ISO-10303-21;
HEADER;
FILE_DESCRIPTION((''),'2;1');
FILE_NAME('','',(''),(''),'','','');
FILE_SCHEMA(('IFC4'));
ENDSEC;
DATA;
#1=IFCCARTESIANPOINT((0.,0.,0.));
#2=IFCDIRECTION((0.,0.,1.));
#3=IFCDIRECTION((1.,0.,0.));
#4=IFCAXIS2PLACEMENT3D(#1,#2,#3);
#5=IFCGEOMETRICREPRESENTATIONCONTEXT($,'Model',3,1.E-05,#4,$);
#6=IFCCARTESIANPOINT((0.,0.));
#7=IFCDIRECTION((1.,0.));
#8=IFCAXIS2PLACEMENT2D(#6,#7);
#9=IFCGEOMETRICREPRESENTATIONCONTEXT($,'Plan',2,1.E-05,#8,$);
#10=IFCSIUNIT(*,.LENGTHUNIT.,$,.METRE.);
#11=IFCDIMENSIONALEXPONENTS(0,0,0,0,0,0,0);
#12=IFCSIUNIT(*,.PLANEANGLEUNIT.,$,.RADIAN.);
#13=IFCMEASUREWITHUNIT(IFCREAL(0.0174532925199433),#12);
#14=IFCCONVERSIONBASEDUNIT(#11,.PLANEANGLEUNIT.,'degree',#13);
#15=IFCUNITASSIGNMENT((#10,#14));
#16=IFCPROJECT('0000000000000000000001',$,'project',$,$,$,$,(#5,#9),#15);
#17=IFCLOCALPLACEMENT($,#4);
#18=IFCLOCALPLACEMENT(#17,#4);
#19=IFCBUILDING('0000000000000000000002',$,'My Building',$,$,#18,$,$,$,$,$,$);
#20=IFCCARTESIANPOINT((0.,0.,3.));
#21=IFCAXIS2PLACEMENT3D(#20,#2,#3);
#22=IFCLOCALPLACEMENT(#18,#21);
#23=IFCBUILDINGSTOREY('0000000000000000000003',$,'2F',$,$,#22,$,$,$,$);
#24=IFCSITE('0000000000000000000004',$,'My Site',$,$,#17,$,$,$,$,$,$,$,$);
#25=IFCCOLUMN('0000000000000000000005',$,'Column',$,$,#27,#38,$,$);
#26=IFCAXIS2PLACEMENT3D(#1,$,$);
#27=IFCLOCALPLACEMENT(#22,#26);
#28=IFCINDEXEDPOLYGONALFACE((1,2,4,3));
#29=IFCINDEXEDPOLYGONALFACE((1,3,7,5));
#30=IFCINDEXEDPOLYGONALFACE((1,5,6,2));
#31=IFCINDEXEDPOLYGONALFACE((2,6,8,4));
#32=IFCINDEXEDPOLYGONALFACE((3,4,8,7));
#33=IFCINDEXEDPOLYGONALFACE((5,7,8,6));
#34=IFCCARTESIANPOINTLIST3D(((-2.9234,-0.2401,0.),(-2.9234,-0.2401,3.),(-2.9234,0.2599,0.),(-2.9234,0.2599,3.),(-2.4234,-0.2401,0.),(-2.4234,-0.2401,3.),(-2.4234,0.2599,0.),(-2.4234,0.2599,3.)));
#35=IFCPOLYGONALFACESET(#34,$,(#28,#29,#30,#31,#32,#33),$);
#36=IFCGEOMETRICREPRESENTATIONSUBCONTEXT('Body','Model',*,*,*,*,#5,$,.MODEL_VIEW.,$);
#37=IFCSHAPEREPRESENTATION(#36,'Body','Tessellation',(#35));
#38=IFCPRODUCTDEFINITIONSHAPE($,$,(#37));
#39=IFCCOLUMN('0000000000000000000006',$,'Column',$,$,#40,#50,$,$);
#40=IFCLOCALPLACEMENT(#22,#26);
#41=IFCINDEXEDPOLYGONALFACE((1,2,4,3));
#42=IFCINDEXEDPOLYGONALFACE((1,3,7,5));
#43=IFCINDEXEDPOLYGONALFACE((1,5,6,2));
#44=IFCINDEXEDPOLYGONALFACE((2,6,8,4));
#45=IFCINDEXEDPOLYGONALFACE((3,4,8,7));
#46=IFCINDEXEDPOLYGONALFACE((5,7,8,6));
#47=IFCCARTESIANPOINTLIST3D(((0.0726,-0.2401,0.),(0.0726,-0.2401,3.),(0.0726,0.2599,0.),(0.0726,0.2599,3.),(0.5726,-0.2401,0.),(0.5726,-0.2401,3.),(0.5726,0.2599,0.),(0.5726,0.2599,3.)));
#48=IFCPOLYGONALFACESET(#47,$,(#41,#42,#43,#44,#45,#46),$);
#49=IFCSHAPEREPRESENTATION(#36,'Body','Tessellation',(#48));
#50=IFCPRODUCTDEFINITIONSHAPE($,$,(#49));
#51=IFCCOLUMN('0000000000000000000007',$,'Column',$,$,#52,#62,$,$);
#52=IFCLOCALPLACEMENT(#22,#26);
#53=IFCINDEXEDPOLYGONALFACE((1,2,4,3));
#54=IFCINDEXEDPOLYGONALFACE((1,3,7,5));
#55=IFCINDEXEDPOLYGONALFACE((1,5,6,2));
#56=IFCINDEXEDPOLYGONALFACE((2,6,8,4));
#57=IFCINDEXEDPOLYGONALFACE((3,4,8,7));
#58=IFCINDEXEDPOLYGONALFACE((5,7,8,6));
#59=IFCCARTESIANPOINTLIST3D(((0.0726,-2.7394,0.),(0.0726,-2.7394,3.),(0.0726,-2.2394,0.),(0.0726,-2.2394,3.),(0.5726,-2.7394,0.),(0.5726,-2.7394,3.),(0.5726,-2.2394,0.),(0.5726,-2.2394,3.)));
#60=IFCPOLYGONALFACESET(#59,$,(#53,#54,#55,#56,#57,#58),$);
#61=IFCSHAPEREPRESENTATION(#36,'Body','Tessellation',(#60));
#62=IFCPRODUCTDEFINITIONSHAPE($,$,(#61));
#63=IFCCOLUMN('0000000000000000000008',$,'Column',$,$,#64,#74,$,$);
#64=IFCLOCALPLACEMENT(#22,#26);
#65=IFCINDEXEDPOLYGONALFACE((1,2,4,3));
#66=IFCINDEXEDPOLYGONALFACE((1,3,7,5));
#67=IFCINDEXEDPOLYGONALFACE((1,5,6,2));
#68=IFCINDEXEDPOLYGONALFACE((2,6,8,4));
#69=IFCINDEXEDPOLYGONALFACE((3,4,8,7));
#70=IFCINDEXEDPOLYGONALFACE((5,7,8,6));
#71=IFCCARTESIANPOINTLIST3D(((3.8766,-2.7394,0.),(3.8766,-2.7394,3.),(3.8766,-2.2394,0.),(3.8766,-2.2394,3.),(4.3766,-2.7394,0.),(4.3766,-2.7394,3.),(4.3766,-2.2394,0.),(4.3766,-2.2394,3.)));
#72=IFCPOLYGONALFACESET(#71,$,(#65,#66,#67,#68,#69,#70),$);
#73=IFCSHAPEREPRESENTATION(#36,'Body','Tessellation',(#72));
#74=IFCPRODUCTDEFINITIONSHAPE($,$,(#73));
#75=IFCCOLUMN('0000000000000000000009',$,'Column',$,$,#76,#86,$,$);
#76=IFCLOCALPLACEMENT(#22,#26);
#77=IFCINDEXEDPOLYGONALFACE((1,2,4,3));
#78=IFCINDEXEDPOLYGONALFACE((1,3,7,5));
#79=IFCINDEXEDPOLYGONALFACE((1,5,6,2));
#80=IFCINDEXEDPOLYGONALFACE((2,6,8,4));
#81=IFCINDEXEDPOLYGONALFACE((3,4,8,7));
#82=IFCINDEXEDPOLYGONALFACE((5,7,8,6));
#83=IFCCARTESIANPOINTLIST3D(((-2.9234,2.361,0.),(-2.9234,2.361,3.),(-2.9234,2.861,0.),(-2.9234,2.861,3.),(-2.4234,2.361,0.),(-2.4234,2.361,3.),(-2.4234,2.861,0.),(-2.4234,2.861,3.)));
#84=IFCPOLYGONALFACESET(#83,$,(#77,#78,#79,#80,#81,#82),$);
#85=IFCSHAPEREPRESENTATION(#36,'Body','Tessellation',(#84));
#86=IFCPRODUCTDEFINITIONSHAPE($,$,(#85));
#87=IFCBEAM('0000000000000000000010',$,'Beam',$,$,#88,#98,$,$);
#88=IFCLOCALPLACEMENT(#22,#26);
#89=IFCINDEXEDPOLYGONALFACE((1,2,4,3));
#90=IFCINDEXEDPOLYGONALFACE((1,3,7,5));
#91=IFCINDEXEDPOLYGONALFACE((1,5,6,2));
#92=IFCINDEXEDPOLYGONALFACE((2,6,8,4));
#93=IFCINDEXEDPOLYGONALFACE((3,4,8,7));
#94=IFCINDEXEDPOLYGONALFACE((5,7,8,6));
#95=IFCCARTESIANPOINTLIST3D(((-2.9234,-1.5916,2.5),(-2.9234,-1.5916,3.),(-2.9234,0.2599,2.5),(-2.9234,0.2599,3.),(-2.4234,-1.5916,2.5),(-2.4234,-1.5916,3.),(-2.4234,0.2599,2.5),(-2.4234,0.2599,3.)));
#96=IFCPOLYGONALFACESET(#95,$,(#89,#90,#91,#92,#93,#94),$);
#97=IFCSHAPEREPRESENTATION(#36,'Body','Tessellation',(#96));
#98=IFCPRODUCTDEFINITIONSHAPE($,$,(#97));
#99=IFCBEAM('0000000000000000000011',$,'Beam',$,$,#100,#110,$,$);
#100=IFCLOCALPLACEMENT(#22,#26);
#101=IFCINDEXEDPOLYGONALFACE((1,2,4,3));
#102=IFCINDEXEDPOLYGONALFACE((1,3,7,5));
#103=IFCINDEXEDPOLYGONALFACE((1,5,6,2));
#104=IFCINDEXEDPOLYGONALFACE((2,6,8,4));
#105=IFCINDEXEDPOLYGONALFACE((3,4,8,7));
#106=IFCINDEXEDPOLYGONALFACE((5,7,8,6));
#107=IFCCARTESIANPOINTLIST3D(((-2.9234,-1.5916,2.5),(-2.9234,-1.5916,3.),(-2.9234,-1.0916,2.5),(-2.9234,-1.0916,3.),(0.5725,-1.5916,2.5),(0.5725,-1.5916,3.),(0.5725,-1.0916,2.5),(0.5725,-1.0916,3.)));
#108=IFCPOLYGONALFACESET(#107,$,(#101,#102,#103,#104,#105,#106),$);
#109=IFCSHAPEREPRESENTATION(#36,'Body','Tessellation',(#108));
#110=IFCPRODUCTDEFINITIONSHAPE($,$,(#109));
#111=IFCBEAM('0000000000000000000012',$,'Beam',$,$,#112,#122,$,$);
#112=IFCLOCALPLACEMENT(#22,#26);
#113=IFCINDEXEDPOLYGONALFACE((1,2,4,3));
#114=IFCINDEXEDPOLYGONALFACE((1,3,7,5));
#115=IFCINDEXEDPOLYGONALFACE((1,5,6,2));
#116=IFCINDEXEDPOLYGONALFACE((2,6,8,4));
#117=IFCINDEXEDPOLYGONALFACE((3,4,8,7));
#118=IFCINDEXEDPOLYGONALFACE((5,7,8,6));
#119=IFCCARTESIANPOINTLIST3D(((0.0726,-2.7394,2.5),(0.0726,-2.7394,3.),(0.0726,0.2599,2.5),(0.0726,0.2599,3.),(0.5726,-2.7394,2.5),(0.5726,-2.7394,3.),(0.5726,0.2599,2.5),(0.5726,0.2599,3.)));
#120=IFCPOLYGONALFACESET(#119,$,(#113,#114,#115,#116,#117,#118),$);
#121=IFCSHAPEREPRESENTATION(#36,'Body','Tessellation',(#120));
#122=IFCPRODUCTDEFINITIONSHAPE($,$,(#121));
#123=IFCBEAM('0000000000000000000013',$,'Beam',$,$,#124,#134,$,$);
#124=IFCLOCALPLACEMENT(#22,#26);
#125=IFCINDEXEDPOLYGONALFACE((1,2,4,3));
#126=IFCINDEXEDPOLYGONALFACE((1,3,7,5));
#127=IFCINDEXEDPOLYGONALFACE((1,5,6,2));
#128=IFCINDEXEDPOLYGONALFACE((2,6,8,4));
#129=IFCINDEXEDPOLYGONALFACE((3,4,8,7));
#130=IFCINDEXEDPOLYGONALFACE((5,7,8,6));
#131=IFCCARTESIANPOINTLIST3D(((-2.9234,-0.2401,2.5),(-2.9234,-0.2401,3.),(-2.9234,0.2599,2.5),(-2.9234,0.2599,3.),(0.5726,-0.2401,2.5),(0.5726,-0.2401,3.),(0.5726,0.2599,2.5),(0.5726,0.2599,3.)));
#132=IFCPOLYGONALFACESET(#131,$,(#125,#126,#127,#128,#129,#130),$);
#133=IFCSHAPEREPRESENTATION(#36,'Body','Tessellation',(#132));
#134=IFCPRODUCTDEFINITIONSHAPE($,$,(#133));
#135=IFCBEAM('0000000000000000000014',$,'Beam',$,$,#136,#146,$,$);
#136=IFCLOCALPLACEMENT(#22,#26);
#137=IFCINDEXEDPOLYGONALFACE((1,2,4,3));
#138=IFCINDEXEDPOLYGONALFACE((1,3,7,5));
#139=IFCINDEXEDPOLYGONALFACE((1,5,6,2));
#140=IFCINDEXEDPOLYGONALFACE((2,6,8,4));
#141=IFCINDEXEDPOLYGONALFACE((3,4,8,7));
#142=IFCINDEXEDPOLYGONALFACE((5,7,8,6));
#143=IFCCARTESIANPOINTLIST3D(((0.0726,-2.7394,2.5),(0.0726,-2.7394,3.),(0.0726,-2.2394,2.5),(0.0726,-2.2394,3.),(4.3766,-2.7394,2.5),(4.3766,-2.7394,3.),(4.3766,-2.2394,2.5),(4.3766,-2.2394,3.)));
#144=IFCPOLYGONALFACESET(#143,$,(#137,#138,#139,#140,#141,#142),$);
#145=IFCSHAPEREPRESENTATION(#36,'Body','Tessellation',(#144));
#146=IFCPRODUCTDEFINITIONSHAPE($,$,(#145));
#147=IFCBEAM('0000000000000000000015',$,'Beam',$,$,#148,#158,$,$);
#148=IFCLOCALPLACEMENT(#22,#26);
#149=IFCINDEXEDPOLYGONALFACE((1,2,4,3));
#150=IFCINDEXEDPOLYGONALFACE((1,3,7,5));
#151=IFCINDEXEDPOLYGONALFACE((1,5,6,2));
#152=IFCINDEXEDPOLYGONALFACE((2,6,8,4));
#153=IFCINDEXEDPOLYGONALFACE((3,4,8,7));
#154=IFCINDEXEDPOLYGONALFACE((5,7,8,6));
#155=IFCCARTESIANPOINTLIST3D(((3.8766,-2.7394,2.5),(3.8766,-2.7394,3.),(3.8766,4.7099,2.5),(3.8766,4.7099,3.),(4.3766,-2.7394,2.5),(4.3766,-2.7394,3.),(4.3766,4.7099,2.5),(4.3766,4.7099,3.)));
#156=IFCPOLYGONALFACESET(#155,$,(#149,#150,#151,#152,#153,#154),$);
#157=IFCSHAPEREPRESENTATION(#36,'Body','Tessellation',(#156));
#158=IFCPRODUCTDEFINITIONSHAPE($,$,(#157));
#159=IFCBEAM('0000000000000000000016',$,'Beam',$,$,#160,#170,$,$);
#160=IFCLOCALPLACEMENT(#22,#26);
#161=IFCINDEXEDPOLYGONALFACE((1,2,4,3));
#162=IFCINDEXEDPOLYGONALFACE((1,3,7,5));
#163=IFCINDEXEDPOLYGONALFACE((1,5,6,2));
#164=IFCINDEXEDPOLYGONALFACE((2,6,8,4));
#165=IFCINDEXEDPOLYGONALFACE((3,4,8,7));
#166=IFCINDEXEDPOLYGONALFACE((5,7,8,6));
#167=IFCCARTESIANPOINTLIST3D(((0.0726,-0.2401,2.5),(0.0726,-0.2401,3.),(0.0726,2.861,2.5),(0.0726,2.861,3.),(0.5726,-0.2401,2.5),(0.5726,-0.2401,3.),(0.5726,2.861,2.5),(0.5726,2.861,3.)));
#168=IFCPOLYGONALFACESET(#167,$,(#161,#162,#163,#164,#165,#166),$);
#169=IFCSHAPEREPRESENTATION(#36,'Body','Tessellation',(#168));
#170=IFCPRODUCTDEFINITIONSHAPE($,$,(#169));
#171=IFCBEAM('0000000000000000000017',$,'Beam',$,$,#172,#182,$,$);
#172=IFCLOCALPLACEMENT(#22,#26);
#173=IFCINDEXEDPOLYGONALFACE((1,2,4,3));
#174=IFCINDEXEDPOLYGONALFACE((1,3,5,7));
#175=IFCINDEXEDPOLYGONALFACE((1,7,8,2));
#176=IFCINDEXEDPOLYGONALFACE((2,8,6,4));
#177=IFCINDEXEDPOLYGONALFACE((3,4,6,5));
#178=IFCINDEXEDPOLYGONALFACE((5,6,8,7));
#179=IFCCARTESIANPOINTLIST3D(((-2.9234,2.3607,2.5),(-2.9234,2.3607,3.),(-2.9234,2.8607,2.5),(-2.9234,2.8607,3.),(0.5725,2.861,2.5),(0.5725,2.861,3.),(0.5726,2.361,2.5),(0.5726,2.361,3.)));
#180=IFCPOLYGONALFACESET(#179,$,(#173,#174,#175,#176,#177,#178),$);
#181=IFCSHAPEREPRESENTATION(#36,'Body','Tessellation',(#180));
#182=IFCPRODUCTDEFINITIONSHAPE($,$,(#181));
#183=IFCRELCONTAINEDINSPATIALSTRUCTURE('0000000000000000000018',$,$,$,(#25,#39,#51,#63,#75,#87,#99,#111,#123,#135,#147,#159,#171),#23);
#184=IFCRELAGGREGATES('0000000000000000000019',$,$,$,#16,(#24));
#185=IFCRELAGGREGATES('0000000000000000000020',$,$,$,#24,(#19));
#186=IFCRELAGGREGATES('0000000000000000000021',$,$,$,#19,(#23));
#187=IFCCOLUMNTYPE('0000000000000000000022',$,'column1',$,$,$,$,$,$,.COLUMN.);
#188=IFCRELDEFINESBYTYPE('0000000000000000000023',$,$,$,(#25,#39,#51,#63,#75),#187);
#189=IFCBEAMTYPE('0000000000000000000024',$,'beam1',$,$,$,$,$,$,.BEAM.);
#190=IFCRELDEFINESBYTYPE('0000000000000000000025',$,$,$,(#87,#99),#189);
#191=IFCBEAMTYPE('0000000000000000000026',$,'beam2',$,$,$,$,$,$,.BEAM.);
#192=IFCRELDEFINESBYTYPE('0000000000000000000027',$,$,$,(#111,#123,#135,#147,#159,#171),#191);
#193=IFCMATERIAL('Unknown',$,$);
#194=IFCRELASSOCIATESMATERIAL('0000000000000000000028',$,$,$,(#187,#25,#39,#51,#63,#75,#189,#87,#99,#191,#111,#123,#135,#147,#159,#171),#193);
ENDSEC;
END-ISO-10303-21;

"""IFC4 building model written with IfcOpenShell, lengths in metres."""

from ifc_helpers import new_model, entity, si_unit, converted_unit, frame, origin_with_axes, origin_2d_with_axis, place, context, subcontext, project, spatial, rectangle, extrude, material, material_profile, profile_set, profile_usage, type_object, element, save


model = new_model("IFC4")

# Units and contexts
model_context = context("Model", 3, precision=1e-05, world=origin_with_axes())
plan_context = context("Plan", 2, precision=1e-05, world=origin_2d_with_axis())
body_context_1 = subcontext(model_context, "Body", "Model", "MODEL_VIEW")
ifc_project = project(units=[si_unit("LENGTHUNIT", "METRE"), converted_unit("PLANEANGLEUNIT", "degree", entity("IfcReal", 0.0174532925199433), si_unit("PLANEANGLEUNIT", "RADIAN"), dimensions=[0, 0, 0, 0, 0, 0, 0])], contexts=[model_context, plan_context])

# Site, building, storey
site_placement = place(None, origin_with_axes())
site = spatial("IfcSite", under=ifc_project, at=site_placement, Name="My Site")
building_placement = place(site_placement, origin_with_axes())
building = spatial("IfcBuilding", under=site, at=building_placement, Name="My Building")
storey_placement = place(building_placement, frame((0.0, 0.0, 3.0), z_axis=(0.0, 0.0, 1.0), x_axis=(1.0, 0.0, 0.0)))
storey = spatial("IfcBuildingStorey", under=building, at=storey_placement, Name="2F")

# Columns
ifc_material = material(Name="Unknown")
ifc_material_profile_1 = material_profile(ifc_material, rectangle(XDim=0.5, YDim=0.5))
ifc_profile_set_1 = profile_set([ifc_material_profile_1])
ifc_profile_usage_1 = profile_usage(ifc_profile_set_1, cardinal=7)
column_type = type_object("IfcColumnType", Name="column1", PredefinedType="COLUMN", material=ifc_profile_set_1)
column_1_placement = place(storey_placement, frame((-2.4234, 0.2599, 0.0), z_axis=(0.0, 0.0, 1.0), x_axis=(1.0, 0.0, 0.0)))
element("IfcColumn", 1, at=column_1_placement, inside=storey, type_object=column_type, material=ifc_profile_usage_1, Name="Column", context=body_context_1, shape_type="SweptSolid", body=[
    extrude(rectangle(XDim=0.5, YDim=0.5), frame((-0.25, -0.25, 0.0), z_axis=(0.0, 0.0, 1.0), x_axis=(1.0, 0.0, 0.0)), (0.0, 0.0, 1.0), 3.0),
])
ifc_profile_usage_2 = profile_usage(ifc_profile_set_1, cardinal=7)
column_2_placement = place(storey_placement, frame((0.5726, 0.2599, 0.0), z_axis=(0.0, 0.0, 1.0), x_axis=(1.0, 0.0, 0.0)))
element("IfcColumn", 2, at=column_2_placement, inside=storey, type_object=column_type, material=ifc_profile_usage_2, Name="Column", context=body_context_1, shape_type="SweptSolid", body=[
    extrude(rectangle(XDim=0.5, YDim=0.5), frame((-0.25, -0.25, 0.0), z_axis=(0.0, 0.0, 1.0), x_axis=(1.0, 0.0, 0.0)), (0.0, 0.0, 1.0), 3.0),
])
ifc_profile_usage_3 = profile_usage(ifc_profile_set_1, cardinal=7)
column_3_placement = place(storey_placement, frame((0.5726, -2.2394, 0.0), z_axis=(0.0, 0.0, 1.0), x_axis=(1.0, 0.0, 0.0)))
element("IfcColumn", 3, at=column_3_placement, inside=storey, type_object=column_type, material=ifc_profile_usage_3, Name="Column", context=body_context_1, shape_type="SweptSolid", body=[
    extrude(rectangle(XDim=0.5, YDim=0.5), frame((-0.25, -0.25, 0.0), z_axis=(0.0, 0.0, 1.0), x_axis=(1.0, 0.0, 0.0)), (0.0, 0.0, 1.0), 3.0),
])
ifc_profile_usage_4 = profile_usage(ifc_profile_set_1, cardinal=7)
column_4_placement = place(storey_placement, frame((4.3766, -2.2394, 0.0), z_axis=(0.0, 0.0, 1.0), x_axis=(1.0, 0.0, 0.0)))
element("IfcColumn", 4, at=column_4_placement, inside=storey, type_object=column_type, material=ifc_profile_usage_4, Name="Column", context=body_context_1, shape_type="SweptSolid", body=[
    extrude(rectangle(XDim=0.5, YDim=0.5), frame((-0.25, -0.25, 0.0), z_axis=(0.0, 0.0, 1.0), x_axis=(1.0, 0.0, 0.0)), (0.0, 0.0, 1.0), 3.0),
])
ifc_profile_usage_5 = profile_usage(ifc_profile_set_1, cardinal=7)
column_5_placement = place(storey_placement, frame((-2.4234, 2.861, 0.0), z_axis=(0.0, 0.0, 1.0), x_axis=(1.0, 0.0, 0.0)))
element("IfcColumn", 5, at=column_5_placement, inside=storey, type_object=column_type, material=ifc_profile_usage_5, Name="Column", context=body_context_1, shape_type="SweptSolid", body=[
    extrude(rectangle(XDim=0.5, YDim=0.5), frame((-0.25, -0.25, 0.0), z_axis=(0.0, 0.0, 1.0), x_axis=(1.0, 0.0, 0.0)), (0.0, 0.0, 1.0), 3.0),
])

# Beams
ifc_material_profile_2 = material_profile(ifc_material, rectangle(XDim=0.5, YDim=0.5))
ifc_profile_set_2 = profile_set([ifc_material_profile_2])
ifc_profile_usage_6 = profile_usage(ifc_profile_set_2, cardinal=7)
beam_type_1 = type_object("IfcBeamType", Name="beam1", PredefinedType="BEAM", material=ifc_profile_set_2)
beam_1_placement = place(storey_placement, frame((-2.4234, 0.2599, 3.0), z_axis=(0.0, -1.0, 0.0), x_axis=(1.0, 0.0, 0.0)))
element("IfcBeam", 6, at=beam_1_placement, inside=storey, type_object=beam_type_1, material=ifc_profile_usage_6, Name="Beam", context=body_context_1, shape_type="SweptSolid", body=[
    extrude(rectangle(XDim=0.5, YDim=0.5), frame((-0.25, -0.25, 0.0), z_axis=(0.0, 0.0, 1.0), x_axis=(1.0, 0.0, 0.0)), (0.0, 0.0, 1.0), 1.8514),
])
ifc_profile_usage_7 = profile_usage(ifc_profile_set_2, cardinal=7)
beam_2_placement = place(storey_placement, frame((-2.9234, -1.0916, 3.0), z_axis=(1.0, -0.000001, 0.000001), x_axis=(0.000001, 1.0, 0.0)))
element("IfcBeam", 7, at=beam_2_placement, inside=storey, type_object=beam_type_1, material=ifc_profile_usage_7, Name="Beam", context=body_context_1, shape_type="SweptSolid", body=[
    extrude(rectangle(XDim=0.5, YDim=0.5), frame((-0.25, -0.25, 0.0), z_axis=(0.0, 0.0, 1.0), x_axis=(1.0, 0.0, 0.0)), (0.0, 0.0, 1.0), 3.4959),
])
ifc_material_profile_3 = material_profile(ifc_material, rectangle(XDim=0.5, YDim=0.5))
ifc_profile_set_3 = profile_set([ifc_material_profile_3])
ifc_profile_usage_8 = profile_usage(ifc_profile_set_3, cardinal=7)
beam_type_2 = type_object("IfcBeamType", Name="beam2", PredefinedType="BEAM", material=ifc_profile_set_3)
beam_3_placement = place(storey_placement, frame((0.5726, 0.2599, 3.0), z_axis=(0.0, -1.0, 0.0), x_axis=(1.0, 0.0, 0.0)))
element("IfcBeam", 8, at=beam_3_placement, inside=storey, type_object=beam_type_2, material=ifc_profile_usage_8, Name="Beam", context=body_context_1, shape_type="SweptSolid", body=[
    extrude(rectangle(XDim=0.5, YDim=0.5), frame((-0.25, -0.25, 0.0), z_axis=(0.0, 0.0, 1.0), x_axis=(1.0, 0.0, 0.0)), (0.0, 0.0, 1.0), 2.9993),
])
ifc_profile_usage_9 = profile_usage(ifc_profile_set_3, cardinal=7)
beam_4_placement = place(storey_placement, frame((-2.9234, 0.2599, 3.0), z_axis=(1.0, -0.000001, 0.000001), x_axis=(0.000001, 1.0, 0.0)))
element("IfcBeam", 9, at=beam_4_placement, inside=storey, type_object=beam_type_2, material=ifc_profile_usage_9, Name="Beam", context=body_context_1, shape_type="SweptSolid", body=[
    extrude(rectangle(XDim=0.5, YDim=0.5), frame((-0.25, -0.25, 0.0), z_axis=(0.0, 0.0, 1.0), x_axis=(1.0, 0.0, 0.0)), (0.0, 0.0, 1.0), 3.496),
])
ifc_profile_usage_10 = profile_usage(ifc_profile_set_3, cardinal=7)
beam_5_placement = place(storey_placement, frame((0.0726, -2.2394, 3.0), z_axis=(1.0, 0.0, 0.0), x_axis=(0.0, 1.0, 0.0)))
element("IfcBeam", 10, at=beam_5_placement, inside=storey, type_object=beam_type_2, material=ifc_profile_usage_10, Name="Beam", context=body_context_1, shape_type="SweptSolid", body=[
    extrude(rectangle(XDim=0.5, YDim=0.5), frame((-0.25, -0.25, 0.0), z_axis=(0.0, 0.0, 1.0), x_axis=(1.0, 0.0, 0.0)), (0.0, 0.0, 1.0), 4.304),
])
ifc_profile_usage_11 = profile_usage(ifc_profile_set_3, cardinal=7)
beam_6_placement = place(storey_placement, frame((3.8766, -2.7394, 3.0), z_axis=(0.0, 1.0, 0.0), x_axis=(-1.0, 0.0, 0.0)))
element("IfcBeam", 11, at=beam_6_placement, inside=storey, type_object=beam_type_2, material=ifc_profile_usage_11, Name="Beam", context=body_context_1, shape_type="SweptSolid", body=[
    extrude(rectangle(XDim=0.5, YDim=0.5), frame((-0.25, -0.25, 0.0), z_axis=(0.0, 0.0, 1.0), x_axis=(1.0, 0.0, 0.0)), (0.0, 0.0, 1.0), 7.4493),
])
ifc_profile_usage_12 = profile_usage(ifc_profile_set_3, cardinal=7)
beam_7_placement = place(storey_placement, frame((0.0726, -0.2401, 3.0), z_axis=(0.0, 1.0, 0.0), x_axis=(-1.0, 0.0, 0.0)))
element("IfcBeam", 12, at=beam_7_placement, inside=storey, type_object=beam_type_2, material=ifc_profile_usage_12, Name="Beam", context=body_context_1, shape_type="SweptSolid", body=[
    extrude(rectangle(XDim=0.5, YDim=0.5), frame((-0.25, -0.25, 0.0), z_axis=(0.0, 0.0, 1.0), x_axis=(1.0, 0.0, 0.0)), (0.0, 0.0, 1.0), 3.1011),
])
ifc_profile_usage_13 = profile_usage(ifc_profile_set_3, cardinal=7)
beam_8_placement = place(storey_placement, frame((0.5726, 2.361, 3.0), z_axis=(-1.0, -0.000105, 0.0), x_axis=(0.000105, -1.0, 0.0)))
element("IfcBeam", 13, at=beam_8_placement, inside=storey, type_object=beam_type_2, material=ifc_profile_usage_13, Name="Beam", context=body_context_1, shape_type="SweptSolid", body=[
    extrude(rectangle(XDim=0.5, YDim=0.5), frame((-0.25, -0.25, 0.0), z_axis=(0.0, 0.0, 1.0), x_axis=(1.0, 0.0, 0.0)), (0.0, 0.0, 1.0), 3.496),
])

save(model, "model.ifc")
